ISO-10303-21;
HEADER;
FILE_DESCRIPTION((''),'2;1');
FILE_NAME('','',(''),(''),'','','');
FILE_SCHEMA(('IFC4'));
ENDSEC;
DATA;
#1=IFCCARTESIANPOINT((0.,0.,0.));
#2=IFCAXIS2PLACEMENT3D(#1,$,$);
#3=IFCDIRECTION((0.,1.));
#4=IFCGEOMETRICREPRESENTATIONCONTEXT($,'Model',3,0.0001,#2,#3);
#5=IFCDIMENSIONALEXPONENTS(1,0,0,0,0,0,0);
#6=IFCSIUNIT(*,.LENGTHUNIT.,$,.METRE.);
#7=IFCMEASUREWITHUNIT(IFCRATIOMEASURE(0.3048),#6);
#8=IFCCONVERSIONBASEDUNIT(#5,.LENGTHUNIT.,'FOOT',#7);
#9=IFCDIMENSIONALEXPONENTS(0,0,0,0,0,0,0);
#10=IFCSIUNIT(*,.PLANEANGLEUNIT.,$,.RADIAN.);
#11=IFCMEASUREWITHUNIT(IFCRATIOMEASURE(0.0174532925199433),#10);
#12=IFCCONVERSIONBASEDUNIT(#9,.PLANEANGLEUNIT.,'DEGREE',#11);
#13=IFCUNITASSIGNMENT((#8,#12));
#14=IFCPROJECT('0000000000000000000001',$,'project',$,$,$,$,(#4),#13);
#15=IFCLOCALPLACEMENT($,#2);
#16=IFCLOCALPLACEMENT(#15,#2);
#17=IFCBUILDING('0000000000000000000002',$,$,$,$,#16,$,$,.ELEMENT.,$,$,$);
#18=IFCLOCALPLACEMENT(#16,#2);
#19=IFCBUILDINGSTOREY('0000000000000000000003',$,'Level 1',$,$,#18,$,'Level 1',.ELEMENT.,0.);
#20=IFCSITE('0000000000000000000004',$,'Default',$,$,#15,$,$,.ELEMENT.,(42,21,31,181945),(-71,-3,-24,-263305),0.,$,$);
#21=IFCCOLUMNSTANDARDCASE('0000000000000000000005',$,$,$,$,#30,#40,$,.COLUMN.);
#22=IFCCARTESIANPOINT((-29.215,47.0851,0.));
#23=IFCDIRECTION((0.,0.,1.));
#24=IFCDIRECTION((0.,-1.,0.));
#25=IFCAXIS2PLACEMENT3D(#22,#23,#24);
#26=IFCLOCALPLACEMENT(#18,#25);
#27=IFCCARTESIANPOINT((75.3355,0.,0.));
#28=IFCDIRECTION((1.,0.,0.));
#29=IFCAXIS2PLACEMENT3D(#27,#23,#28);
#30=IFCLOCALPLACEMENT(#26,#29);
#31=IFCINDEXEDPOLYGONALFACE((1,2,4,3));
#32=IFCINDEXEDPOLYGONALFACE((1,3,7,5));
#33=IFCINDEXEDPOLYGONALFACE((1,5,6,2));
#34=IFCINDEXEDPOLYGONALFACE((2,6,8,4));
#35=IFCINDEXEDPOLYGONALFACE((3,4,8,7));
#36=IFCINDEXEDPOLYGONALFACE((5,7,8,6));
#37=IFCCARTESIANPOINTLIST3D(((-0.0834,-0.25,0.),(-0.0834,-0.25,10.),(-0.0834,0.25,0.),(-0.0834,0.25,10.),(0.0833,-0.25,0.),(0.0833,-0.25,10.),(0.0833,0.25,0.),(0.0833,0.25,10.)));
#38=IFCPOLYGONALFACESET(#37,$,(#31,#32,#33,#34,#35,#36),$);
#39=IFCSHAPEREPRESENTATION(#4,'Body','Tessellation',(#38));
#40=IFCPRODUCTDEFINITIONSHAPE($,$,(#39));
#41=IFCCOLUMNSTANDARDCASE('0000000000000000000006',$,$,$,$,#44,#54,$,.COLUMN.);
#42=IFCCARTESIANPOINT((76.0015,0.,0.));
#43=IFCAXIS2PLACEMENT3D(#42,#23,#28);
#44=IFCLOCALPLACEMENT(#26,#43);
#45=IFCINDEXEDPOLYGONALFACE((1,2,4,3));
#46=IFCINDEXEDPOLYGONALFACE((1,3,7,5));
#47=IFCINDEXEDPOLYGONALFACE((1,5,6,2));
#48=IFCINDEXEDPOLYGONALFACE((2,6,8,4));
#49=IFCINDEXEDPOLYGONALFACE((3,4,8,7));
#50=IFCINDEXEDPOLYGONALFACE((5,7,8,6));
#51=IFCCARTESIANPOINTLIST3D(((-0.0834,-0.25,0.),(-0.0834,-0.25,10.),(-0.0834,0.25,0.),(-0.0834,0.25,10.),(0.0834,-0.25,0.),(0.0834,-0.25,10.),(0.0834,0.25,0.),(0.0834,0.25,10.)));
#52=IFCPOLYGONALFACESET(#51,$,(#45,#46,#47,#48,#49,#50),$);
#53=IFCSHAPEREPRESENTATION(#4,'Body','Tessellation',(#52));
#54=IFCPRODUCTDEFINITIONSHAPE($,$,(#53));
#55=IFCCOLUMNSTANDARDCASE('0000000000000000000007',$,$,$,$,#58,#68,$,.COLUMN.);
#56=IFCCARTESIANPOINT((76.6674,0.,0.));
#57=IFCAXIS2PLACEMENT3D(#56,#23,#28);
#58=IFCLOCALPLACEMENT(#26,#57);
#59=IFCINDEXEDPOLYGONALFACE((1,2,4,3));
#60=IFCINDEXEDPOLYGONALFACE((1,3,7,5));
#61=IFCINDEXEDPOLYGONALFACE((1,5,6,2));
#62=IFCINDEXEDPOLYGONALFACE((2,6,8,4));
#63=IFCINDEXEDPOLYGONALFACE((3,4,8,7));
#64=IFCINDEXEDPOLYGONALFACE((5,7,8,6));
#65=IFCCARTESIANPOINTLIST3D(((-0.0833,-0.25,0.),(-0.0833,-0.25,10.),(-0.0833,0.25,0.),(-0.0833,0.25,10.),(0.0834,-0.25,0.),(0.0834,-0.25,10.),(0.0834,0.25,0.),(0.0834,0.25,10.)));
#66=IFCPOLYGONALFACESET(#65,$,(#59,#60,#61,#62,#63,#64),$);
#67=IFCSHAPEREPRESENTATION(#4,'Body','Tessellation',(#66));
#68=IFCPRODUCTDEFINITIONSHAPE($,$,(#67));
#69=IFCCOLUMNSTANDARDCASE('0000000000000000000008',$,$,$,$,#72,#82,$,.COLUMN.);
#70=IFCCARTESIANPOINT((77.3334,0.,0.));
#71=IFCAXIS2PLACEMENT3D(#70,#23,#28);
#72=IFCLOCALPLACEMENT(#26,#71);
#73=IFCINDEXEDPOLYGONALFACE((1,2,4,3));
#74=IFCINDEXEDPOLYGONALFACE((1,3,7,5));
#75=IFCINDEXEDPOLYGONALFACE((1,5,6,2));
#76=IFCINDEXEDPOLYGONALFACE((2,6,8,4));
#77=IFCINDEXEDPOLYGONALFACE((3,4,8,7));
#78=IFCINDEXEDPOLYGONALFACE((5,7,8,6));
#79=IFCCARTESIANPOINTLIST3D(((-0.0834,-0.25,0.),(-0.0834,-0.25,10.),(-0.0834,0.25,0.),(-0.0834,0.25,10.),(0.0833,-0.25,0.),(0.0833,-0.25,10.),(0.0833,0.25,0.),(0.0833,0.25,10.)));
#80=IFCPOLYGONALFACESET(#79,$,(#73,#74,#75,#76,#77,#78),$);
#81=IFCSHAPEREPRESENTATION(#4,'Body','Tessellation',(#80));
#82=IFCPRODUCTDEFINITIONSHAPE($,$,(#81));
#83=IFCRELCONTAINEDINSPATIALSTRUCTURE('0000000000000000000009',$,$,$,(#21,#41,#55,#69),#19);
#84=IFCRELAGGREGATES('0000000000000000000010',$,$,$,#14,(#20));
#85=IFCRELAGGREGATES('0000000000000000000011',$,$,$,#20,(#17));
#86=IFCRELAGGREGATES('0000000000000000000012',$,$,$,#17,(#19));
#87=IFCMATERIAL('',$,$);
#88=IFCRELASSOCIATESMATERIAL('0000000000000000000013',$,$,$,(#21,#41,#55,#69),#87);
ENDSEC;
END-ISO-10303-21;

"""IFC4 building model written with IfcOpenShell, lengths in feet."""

from ifc_helpers import new_model, entity, si_unit, converted_unit, direction, frame, origin, place, context, project, spatial, rectangle, extrude, material, element, save


model = new_model("IFC4")

# Units and contexts
model_context = context("Model", 3, precision=0.0001, world=origin(), true_north=direction((0.0, 1.0)))
ifc_project = project(units=[converted_unit("LENGTHUNIT", "FOOT", entity("IfcRatioMeasure", 0.3048), si_unit("LENGTHUNIT", "METRE"), dimensions=[1, 0, 0, 0, 0, 0, 0]), converted_unit("PLANEANGLEUNIT", "DEGREE", entity("IfcRatioMeasure", 0.0174532925199433), si_unit("PLANEANGLEUNIT", "RADIAN"), dimensions=[0, 0, 0, 0, 0, 0, 0])], contexts=[model_context])

# Site, building, storey
site_placement = place(None, origin())
site = spatial("IfcSite", under=ifc_project, at=site_placement, Name="Default", CompositionType="ELEMENT", RefLatitude=(42, 21, 31, 181945), RefLongitude=(-71, -3, -24, -263305), RefElevation=0.0)
building_placement = place(site_placement, origin())
building = spatial("IfcBuilding", under=site, at=building_placement, CompositionType="ELEMENT")
storey_placement = place(building_placement, origin())
storey = spatial("IfcBuildingStorey", under=building, at=storey_placement, Name="Level 1", LongName="Level 1", CompositionType="ELEMENT", Elevation=0.0)

# Columns
ifc_material_1 = material(Name="")
placement = place(storey_placement, frame((-29.215, 47.0851, 0.0), z_axis=(0.0, 0.0, 1.0), x_axis=(0.0, -1.0, 0.0)))
for number, where, z_axis, x_axis in (
    (1, (75.3355, 0.0, 0.0), (0.0, 0.0, 1.0), (1.0, 0.0, 0.0)),
    (2, (76.0015, 0.0, 0.0), (0.0, 0.0, 1.0), (1.0, 0.0, 0.0)),
    (3, (76.6674, 0.0, 0.0), (0.0, 0.0, 1.0), (1.0, 0.0, 0.0)),
    (4, (77.3334, 0.0, 0.0), (0.0, 0.0, 1.0), (1.0, 0.0, 0.0)),
):
    element("IfcColumnStandardCase", number, at=place(placement, frame(where, z_axis=z_axis, x_axis=x_axis)), inside=storey, material=ifc_material_1, PredefinedType="COLUMN", context=model_context, shape_type="SweptSolid", body=[
        extrude(rectangle(XDim=0.1667, YDim=0.5), origin(), (0.0, 0.0, 1.0), 10.0),
    ])

save(model, "model.ifc")
